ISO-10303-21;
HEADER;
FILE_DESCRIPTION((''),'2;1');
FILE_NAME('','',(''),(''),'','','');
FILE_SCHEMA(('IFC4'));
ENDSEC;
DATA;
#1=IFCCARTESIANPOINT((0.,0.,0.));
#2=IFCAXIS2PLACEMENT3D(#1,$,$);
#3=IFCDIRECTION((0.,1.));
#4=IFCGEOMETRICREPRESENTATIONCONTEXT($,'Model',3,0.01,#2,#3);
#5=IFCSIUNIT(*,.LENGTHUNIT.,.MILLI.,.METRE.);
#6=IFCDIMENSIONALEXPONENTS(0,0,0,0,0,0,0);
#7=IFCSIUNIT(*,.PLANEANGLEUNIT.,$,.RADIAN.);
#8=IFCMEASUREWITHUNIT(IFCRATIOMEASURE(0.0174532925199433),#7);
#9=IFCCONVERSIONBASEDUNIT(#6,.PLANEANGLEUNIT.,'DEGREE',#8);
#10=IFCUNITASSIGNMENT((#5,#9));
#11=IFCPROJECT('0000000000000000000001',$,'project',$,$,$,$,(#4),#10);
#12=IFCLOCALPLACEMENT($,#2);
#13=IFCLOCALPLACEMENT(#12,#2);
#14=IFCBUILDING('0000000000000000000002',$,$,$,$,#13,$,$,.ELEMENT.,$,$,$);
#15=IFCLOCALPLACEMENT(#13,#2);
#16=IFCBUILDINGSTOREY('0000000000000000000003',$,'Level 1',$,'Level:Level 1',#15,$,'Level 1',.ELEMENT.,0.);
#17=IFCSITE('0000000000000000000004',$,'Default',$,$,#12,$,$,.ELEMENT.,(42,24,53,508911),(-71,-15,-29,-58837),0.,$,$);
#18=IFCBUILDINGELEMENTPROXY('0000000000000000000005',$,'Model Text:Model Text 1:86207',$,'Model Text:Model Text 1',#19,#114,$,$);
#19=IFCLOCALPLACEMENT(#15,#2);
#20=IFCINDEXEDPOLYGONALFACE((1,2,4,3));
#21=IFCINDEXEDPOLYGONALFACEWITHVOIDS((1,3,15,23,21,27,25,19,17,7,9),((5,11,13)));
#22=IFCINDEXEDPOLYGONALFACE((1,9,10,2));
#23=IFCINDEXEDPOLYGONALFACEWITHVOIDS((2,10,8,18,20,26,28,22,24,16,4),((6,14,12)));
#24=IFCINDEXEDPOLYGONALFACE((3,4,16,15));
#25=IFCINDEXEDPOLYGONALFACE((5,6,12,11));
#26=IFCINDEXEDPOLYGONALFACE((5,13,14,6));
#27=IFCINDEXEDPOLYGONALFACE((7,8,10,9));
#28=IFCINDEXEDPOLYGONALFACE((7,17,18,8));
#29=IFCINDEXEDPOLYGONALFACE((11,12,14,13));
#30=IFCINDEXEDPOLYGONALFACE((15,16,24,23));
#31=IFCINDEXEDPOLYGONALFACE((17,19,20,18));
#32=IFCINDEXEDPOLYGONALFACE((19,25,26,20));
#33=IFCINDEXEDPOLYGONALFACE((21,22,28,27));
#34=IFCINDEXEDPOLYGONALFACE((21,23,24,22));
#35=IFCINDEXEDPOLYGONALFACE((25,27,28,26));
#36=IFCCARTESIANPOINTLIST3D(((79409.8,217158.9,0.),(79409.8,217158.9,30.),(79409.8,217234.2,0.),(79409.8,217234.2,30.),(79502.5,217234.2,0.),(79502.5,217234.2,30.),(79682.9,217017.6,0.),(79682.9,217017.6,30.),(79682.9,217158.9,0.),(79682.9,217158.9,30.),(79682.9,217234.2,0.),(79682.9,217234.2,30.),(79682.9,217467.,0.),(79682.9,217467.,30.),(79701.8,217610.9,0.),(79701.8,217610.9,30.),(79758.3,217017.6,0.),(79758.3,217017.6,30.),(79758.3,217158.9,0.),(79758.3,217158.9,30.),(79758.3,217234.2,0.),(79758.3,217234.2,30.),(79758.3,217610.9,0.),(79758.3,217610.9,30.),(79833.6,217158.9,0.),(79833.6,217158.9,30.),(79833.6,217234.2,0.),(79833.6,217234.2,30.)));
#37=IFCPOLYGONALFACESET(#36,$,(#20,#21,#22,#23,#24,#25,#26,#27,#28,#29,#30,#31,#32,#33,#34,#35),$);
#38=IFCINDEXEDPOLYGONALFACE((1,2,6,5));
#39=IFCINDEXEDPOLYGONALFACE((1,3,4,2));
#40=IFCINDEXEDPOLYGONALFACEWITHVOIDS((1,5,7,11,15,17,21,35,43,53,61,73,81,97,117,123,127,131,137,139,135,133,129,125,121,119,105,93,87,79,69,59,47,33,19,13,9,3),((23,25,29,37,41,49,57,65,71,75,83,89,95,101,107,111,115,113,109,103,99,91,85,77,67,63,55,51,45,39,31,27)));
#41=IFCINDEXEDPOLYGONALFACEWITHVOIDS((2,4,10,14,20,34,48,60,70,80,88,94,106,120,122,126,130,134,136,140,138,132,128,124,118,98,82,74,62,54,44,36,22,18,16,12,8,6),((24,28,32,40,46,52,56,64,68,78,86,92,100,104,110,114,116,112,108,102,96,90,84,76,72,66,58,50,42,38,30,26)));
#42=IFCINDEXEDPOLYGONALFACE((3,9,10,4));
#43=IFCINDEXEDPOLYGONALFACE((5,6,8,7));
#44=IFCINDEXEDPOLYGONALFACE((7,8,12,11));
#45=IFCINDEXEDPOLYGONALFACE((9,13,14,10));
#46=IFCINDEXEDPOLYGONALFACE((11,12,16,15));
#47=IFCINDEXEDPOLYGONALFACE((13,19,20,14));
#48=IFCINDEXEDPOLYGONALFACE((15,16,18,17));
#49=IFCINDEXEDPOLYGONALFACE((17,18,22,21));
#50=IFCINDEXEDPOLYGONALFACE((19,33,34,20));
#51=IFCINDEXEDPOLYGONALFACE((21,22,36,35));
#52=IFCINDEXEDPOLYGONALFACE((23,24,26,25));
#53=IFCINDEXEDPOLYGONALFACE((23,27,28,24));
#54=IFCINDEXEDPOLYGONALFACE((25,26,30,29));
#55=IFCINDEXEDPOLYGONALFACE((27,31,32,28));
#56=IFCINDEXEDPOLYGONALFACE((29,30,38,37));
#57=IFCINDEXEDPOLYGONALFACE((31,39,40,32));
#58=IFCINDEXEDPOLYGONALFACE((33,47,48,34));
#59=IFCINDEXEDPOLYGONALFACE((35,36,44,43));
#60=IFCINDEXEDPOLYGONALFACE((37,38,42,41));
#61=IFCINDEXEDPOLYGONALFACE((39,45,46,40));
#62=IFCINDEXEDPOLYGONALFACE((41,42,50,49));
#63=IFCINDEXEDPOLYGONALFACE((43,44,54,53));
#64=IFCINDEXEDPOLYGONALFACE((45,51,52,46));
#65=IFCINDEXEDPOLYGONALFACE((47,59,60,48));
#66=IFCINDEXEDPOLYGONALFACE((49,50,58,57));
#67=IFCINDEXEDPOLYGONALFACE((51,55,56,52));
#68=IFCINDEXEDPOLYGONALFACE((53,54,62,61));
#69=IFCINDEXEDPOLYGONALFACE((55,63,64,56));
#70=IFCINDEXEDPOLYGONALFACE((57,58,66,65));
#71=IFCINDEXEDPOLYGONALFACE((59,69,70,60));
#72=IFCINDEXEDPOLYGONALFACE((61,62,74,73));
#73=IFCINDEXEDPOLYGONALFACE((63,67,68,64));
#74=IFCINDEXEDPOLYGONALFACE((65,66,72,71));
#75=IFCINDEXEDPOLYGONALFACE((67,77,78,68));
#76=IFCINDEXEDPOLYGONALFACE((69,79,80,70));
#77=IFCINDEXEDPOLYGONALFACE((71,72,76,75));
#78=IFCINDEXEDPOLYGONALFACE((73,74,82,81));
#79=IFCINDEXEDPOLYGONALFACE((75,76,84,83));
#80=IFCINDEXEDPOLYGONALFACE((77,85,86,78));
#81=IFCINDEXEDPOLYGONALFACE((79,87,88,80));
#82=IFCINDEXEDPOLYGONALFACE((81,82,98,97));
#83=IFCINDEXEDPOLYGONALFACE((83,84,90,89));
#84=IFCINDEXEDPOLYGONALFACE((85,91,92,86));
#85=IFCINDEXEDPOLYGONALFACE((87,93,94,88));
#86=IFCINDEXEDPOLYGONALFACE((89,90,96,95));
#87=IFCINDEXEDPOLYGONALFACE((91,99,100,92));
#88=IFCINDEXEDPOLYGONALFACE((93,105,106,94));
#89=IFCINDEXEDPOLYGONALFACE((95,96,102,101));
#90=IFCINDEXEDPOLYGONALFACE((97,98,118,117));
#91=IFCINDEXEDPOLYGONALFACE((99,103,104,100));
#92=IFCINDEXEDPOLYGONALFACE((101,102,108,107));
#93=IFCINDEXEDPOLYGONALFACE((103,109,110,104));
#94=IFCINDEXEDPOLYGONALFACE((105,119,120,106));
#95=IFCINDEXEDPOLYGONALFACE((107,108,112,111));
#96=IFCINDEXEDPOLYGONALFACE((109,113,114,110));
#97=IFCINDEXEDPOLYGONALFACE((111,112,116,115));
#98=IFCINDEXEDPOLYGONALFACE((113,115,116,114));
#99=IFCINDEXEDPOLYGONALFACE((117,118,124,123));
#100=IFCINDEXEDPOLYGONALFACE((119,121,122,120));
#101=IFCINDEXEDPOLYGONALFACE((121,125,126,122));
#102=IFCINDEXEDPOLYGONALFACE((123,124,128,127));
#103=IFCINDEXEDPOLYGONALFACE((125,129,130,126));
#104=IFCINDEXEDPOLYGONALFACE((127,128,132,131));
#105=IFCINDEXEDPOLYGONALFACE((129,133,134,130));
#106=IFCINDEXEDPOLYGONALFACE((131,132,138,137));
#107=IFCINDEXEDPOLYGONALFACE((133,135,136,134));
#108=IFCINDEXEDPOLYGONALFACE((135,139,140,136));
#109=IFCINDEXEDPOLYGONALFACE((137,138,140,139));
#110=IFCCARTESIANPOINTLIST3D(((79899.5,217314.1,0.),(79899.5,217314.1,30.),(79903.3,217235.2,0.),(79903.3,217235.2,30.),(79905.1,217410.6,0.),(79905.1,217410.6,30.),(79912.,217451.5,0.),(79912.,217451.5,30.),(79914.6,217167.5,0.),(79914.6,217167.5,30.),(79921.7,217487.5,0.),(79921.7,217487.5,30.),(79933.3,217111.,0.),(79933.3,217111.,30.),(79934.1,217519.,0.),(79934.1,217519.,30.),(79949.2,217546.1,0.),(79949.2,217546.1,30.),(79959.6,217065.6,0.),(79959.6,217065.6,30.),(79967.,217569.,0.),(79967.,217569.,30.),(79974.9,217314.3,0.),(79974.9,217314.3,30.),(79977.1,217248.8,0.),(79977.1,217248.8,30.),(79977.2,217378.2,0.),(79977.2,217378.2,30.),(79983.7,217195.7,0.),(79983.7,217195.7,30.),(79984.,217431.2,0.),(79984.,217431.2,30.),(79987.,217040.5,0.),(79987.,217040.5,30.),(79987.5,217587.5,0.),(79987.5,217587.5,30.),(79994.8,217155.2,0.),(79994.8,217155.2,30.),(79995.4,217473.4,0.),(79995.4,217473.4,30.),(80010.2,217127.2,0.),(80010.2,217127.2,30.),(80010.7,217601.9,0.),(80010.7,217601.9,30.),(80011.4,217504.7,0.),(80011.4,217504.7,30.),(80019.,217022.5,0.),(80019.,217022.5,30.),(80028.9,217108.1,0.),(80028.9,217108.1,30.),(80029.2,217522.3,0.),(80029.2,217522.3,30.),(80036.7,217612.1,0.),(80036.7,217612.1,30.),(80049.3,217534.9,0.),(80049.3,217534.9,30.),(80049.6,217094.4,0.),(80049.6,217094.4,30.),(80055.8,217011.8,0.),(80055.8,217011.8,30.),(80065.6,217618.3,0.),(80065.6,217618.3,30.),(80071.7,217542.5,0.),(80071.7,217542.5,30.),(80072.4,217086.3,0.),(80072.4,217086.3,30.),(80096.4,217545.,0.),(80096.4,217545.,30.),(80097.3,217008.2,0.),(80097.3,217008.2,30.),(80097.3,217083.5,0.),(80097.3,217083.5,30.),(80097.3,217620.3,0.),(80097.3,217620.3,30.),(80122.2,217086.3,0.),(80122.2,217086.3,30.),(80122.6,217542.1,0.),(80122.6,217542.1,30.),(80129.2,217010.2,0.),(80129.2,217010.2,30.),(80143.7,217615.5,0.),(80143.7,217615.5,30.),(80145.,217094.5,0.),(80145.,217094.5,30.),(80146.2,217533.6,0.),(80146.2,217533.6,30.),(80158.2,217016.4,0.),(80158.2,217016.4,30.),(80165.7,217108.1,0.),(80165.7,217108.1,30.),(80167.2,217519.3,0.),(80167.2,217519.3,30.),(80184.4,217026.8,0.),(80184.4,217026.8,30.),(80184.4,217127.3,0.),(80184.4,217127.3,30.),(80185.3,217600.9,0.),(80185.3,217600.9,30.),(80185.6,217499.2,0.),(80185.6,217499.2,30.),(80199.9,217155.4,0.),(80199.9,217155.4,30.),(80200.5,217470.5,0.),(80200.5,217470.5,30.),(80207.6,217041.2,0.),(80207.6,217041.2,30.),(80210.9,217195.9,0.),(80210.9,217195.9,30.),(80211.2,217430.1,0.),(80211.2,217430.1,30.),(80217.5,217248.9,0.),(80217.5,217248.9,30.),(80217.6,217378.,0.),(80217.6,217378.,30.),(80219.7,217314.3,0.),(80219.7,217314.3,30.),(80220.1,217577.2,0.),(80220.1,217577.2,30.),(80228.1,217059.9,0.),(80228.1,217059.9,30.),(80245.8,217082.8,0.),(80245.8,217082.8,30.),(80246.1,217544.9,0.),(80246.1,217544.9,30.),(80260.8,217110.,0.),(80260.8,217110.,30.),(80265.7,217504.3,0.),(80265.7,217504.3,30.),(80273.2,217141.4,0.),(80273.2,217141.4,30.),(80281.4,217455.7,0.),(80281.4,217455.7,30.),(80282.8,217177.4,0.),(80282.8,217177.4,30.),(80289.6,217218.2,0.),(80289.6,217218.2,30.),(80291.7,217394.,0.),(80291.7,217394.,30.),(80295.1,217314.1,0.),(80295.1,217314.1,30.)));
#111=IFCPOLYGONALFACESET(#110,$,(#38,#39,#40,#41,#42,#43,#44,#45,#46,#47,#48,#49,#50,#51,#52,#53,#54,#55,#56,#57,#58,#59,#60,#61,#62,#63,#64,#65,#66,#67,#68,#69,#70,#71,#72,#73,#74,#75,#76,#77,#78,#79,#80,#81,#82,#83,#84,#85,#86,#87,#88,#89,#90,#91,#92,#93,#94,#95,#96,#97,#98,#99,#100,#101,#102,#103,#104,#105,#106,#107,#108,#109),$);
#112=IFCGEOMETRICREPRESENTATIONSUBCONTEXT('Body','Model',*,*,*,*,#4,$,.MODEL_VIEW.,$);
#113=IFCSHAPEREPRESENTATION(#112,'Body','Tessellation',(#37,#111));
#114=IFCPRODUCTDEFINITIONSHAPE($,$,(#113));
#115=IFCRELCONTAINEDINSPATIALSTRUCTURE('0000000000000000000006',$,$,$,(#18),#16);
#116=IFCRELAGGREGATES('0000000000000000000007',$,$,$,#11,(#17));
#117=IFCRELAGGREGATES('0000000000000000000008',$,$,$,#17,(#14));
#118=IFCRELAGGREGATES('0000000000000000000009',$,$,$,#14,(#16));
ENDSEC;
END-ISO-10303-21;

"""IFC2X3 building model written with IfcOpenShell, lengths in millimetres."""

from ifc_helpers import new_model, entity, si_unit, converted_unit, direction, frame, origin, place, context, subcontext, project, spatial, polyline, outline, extrude, element, save


model = new_model("IFC2X3")

# Units and contexts
model_context = context("Model", 3, precision=0.01, world=origin(), true_north=direction((0.0, 1.0)))
body_context = subcontext(model_context, "Body", "Model", "MODEL_VIEW")
ifc_project = project(units=[si_unit("LENGTHUNIT", "METRE", prefix="MILLI"), converted_unit("PLANEANGLEUNIT", "DEGREE", entity("IfcRatioMeasure", 0.0174532925199433), si_unit("PLANEANGLEUNIT", "RADIAN"), dimensions=[0, 0, 0, 0, 0, 0, 0])], contexts=[model_context])

# Site, building, storey
site_placement = place(None, origin())
site = spatial("IfcSite", under=ifc_project, at=site_placement, Name="Default", CompositionType="ELEMENT", RefLatitude=(42, 24, 53, 508911), RefLongitude=(-71, -15, -29, -58837), RefElevation=0.0)
building_placement = place(site_placement, origin())
building = spatial("IfcBuilding", under=site, at=building_placement, CompositionType="ELEMENT")
storey_placement = place(building_placement, origin())
storey = spatial("IfcBuildingStorey", under=building, at=storey_placement, Name="Level 1", ObjectType="Level:Level 1", LongName="Level 1", CompositionType="ELEMENT", Elevation=0.0)

# Building element proxy
proxy_1_placement = place(storey_placement, origin())
element("IfcBuildingElementProxy", 1, at=proxy_1_placement, inside=storey, Name="Model Text:Model Text 1:86207", ObjectType="Model Text:Model Text 1", context=body_context, shape_type="SweptSolid", body=[
    extrude(outline(polyline([(-6.8, -218.3), (68.5, -218.3), (68.5, -77.1), (143.8, -77.1), (143.8, -1.7), (68.5, -1.7), (68.5, 375.0), (12.0, 375.0), (-280.0, -1.7), (-280.0, -77.1), (-6.8, -77.1), (-6.8, -218.3)]), holes=[polyline([(-6.8, -1.7), (-187.3, -1.7), (-6.8, 231.1), (-6.8, -1.7)])]), frame((79689.8, 217235.9, 0.0)), (0.0, 0.0, 1.0), 30.0),
    extrude(outline(polyline([(-10.6, -198.7), (68.3, -198.7), (136.5, -190.7), (193.9, -174.7), (240.5, -150.6), (266.9, -124.4), (286.3, -93.2), (298.8, -57.0), (304.3, -15.7), (303.8, 16.2), (299.0, 45.5), (289.9, 72.1), (276.6, 96.0), (258.9, 117.3), (236.9, 136.2), (210.4, 152.5), (179.6, 166.3), (144.1, 177.6), (103.7, 186.3), (8.2, 196.4), (-71.8, 196.7), (-134.0, 189.4), (-183.3, 176.1), (-224.7, 158.4), (-258.2, 133.9), (-283.5, 100.3), (-300.1, 59.5), (-307.1, 13.4), (-306.6, -18.4), (-301.8, -47.5), (-292.8, -74.0), (-279.6, -97.9), (-262.0, -119.2), (-240.0, -138.1), (-213.6, -154.5), (-182.8, -168.4), (-147.3, -179.8), (-106.7, -188.6), (-10.6, -198.7)]), holes=[polyline([(-7.2, -123.5), (-71.0, -118.2), (-123.6, -108.8), (-165.2, -95.4), (-195.7, -78.0), (-212.4, -59.4), (-224.1, -38.7), (-230.6, -15.9), (-231.9, 8.9), (-227.8, 35.0), (-218.1, 58.1), (-202.8, 78.4), (-182.0, 95.8), (-152.6, 109.4), (-111.7, 118.1), (-59.4, 122.0), (4.4, 121.1), (69.6, 115.8), (122.2, 106.7), (162.2, 93.7), (189.5, 77.0), (207.7, 57.4), (220.4, 36.0), (227.5, 12.8), (229.1, -12.1), (225.2, -36.8), (215.9, -59.2), (201.3, -79.3), (181.4, -97.1), (152.6, -111.2), (111.6, -120.3), (58.3, -124.4), (-7.2, -123.5)])]), frame((80098.6, 217312.9, 0.0), z_axis=(0.0, 0.0, 1.0), x_axis=(0.047515, -0.998871, 0.0)), (0.0, 0.0, 1.0), 30.0),
])

save(model, "model.ifc")
